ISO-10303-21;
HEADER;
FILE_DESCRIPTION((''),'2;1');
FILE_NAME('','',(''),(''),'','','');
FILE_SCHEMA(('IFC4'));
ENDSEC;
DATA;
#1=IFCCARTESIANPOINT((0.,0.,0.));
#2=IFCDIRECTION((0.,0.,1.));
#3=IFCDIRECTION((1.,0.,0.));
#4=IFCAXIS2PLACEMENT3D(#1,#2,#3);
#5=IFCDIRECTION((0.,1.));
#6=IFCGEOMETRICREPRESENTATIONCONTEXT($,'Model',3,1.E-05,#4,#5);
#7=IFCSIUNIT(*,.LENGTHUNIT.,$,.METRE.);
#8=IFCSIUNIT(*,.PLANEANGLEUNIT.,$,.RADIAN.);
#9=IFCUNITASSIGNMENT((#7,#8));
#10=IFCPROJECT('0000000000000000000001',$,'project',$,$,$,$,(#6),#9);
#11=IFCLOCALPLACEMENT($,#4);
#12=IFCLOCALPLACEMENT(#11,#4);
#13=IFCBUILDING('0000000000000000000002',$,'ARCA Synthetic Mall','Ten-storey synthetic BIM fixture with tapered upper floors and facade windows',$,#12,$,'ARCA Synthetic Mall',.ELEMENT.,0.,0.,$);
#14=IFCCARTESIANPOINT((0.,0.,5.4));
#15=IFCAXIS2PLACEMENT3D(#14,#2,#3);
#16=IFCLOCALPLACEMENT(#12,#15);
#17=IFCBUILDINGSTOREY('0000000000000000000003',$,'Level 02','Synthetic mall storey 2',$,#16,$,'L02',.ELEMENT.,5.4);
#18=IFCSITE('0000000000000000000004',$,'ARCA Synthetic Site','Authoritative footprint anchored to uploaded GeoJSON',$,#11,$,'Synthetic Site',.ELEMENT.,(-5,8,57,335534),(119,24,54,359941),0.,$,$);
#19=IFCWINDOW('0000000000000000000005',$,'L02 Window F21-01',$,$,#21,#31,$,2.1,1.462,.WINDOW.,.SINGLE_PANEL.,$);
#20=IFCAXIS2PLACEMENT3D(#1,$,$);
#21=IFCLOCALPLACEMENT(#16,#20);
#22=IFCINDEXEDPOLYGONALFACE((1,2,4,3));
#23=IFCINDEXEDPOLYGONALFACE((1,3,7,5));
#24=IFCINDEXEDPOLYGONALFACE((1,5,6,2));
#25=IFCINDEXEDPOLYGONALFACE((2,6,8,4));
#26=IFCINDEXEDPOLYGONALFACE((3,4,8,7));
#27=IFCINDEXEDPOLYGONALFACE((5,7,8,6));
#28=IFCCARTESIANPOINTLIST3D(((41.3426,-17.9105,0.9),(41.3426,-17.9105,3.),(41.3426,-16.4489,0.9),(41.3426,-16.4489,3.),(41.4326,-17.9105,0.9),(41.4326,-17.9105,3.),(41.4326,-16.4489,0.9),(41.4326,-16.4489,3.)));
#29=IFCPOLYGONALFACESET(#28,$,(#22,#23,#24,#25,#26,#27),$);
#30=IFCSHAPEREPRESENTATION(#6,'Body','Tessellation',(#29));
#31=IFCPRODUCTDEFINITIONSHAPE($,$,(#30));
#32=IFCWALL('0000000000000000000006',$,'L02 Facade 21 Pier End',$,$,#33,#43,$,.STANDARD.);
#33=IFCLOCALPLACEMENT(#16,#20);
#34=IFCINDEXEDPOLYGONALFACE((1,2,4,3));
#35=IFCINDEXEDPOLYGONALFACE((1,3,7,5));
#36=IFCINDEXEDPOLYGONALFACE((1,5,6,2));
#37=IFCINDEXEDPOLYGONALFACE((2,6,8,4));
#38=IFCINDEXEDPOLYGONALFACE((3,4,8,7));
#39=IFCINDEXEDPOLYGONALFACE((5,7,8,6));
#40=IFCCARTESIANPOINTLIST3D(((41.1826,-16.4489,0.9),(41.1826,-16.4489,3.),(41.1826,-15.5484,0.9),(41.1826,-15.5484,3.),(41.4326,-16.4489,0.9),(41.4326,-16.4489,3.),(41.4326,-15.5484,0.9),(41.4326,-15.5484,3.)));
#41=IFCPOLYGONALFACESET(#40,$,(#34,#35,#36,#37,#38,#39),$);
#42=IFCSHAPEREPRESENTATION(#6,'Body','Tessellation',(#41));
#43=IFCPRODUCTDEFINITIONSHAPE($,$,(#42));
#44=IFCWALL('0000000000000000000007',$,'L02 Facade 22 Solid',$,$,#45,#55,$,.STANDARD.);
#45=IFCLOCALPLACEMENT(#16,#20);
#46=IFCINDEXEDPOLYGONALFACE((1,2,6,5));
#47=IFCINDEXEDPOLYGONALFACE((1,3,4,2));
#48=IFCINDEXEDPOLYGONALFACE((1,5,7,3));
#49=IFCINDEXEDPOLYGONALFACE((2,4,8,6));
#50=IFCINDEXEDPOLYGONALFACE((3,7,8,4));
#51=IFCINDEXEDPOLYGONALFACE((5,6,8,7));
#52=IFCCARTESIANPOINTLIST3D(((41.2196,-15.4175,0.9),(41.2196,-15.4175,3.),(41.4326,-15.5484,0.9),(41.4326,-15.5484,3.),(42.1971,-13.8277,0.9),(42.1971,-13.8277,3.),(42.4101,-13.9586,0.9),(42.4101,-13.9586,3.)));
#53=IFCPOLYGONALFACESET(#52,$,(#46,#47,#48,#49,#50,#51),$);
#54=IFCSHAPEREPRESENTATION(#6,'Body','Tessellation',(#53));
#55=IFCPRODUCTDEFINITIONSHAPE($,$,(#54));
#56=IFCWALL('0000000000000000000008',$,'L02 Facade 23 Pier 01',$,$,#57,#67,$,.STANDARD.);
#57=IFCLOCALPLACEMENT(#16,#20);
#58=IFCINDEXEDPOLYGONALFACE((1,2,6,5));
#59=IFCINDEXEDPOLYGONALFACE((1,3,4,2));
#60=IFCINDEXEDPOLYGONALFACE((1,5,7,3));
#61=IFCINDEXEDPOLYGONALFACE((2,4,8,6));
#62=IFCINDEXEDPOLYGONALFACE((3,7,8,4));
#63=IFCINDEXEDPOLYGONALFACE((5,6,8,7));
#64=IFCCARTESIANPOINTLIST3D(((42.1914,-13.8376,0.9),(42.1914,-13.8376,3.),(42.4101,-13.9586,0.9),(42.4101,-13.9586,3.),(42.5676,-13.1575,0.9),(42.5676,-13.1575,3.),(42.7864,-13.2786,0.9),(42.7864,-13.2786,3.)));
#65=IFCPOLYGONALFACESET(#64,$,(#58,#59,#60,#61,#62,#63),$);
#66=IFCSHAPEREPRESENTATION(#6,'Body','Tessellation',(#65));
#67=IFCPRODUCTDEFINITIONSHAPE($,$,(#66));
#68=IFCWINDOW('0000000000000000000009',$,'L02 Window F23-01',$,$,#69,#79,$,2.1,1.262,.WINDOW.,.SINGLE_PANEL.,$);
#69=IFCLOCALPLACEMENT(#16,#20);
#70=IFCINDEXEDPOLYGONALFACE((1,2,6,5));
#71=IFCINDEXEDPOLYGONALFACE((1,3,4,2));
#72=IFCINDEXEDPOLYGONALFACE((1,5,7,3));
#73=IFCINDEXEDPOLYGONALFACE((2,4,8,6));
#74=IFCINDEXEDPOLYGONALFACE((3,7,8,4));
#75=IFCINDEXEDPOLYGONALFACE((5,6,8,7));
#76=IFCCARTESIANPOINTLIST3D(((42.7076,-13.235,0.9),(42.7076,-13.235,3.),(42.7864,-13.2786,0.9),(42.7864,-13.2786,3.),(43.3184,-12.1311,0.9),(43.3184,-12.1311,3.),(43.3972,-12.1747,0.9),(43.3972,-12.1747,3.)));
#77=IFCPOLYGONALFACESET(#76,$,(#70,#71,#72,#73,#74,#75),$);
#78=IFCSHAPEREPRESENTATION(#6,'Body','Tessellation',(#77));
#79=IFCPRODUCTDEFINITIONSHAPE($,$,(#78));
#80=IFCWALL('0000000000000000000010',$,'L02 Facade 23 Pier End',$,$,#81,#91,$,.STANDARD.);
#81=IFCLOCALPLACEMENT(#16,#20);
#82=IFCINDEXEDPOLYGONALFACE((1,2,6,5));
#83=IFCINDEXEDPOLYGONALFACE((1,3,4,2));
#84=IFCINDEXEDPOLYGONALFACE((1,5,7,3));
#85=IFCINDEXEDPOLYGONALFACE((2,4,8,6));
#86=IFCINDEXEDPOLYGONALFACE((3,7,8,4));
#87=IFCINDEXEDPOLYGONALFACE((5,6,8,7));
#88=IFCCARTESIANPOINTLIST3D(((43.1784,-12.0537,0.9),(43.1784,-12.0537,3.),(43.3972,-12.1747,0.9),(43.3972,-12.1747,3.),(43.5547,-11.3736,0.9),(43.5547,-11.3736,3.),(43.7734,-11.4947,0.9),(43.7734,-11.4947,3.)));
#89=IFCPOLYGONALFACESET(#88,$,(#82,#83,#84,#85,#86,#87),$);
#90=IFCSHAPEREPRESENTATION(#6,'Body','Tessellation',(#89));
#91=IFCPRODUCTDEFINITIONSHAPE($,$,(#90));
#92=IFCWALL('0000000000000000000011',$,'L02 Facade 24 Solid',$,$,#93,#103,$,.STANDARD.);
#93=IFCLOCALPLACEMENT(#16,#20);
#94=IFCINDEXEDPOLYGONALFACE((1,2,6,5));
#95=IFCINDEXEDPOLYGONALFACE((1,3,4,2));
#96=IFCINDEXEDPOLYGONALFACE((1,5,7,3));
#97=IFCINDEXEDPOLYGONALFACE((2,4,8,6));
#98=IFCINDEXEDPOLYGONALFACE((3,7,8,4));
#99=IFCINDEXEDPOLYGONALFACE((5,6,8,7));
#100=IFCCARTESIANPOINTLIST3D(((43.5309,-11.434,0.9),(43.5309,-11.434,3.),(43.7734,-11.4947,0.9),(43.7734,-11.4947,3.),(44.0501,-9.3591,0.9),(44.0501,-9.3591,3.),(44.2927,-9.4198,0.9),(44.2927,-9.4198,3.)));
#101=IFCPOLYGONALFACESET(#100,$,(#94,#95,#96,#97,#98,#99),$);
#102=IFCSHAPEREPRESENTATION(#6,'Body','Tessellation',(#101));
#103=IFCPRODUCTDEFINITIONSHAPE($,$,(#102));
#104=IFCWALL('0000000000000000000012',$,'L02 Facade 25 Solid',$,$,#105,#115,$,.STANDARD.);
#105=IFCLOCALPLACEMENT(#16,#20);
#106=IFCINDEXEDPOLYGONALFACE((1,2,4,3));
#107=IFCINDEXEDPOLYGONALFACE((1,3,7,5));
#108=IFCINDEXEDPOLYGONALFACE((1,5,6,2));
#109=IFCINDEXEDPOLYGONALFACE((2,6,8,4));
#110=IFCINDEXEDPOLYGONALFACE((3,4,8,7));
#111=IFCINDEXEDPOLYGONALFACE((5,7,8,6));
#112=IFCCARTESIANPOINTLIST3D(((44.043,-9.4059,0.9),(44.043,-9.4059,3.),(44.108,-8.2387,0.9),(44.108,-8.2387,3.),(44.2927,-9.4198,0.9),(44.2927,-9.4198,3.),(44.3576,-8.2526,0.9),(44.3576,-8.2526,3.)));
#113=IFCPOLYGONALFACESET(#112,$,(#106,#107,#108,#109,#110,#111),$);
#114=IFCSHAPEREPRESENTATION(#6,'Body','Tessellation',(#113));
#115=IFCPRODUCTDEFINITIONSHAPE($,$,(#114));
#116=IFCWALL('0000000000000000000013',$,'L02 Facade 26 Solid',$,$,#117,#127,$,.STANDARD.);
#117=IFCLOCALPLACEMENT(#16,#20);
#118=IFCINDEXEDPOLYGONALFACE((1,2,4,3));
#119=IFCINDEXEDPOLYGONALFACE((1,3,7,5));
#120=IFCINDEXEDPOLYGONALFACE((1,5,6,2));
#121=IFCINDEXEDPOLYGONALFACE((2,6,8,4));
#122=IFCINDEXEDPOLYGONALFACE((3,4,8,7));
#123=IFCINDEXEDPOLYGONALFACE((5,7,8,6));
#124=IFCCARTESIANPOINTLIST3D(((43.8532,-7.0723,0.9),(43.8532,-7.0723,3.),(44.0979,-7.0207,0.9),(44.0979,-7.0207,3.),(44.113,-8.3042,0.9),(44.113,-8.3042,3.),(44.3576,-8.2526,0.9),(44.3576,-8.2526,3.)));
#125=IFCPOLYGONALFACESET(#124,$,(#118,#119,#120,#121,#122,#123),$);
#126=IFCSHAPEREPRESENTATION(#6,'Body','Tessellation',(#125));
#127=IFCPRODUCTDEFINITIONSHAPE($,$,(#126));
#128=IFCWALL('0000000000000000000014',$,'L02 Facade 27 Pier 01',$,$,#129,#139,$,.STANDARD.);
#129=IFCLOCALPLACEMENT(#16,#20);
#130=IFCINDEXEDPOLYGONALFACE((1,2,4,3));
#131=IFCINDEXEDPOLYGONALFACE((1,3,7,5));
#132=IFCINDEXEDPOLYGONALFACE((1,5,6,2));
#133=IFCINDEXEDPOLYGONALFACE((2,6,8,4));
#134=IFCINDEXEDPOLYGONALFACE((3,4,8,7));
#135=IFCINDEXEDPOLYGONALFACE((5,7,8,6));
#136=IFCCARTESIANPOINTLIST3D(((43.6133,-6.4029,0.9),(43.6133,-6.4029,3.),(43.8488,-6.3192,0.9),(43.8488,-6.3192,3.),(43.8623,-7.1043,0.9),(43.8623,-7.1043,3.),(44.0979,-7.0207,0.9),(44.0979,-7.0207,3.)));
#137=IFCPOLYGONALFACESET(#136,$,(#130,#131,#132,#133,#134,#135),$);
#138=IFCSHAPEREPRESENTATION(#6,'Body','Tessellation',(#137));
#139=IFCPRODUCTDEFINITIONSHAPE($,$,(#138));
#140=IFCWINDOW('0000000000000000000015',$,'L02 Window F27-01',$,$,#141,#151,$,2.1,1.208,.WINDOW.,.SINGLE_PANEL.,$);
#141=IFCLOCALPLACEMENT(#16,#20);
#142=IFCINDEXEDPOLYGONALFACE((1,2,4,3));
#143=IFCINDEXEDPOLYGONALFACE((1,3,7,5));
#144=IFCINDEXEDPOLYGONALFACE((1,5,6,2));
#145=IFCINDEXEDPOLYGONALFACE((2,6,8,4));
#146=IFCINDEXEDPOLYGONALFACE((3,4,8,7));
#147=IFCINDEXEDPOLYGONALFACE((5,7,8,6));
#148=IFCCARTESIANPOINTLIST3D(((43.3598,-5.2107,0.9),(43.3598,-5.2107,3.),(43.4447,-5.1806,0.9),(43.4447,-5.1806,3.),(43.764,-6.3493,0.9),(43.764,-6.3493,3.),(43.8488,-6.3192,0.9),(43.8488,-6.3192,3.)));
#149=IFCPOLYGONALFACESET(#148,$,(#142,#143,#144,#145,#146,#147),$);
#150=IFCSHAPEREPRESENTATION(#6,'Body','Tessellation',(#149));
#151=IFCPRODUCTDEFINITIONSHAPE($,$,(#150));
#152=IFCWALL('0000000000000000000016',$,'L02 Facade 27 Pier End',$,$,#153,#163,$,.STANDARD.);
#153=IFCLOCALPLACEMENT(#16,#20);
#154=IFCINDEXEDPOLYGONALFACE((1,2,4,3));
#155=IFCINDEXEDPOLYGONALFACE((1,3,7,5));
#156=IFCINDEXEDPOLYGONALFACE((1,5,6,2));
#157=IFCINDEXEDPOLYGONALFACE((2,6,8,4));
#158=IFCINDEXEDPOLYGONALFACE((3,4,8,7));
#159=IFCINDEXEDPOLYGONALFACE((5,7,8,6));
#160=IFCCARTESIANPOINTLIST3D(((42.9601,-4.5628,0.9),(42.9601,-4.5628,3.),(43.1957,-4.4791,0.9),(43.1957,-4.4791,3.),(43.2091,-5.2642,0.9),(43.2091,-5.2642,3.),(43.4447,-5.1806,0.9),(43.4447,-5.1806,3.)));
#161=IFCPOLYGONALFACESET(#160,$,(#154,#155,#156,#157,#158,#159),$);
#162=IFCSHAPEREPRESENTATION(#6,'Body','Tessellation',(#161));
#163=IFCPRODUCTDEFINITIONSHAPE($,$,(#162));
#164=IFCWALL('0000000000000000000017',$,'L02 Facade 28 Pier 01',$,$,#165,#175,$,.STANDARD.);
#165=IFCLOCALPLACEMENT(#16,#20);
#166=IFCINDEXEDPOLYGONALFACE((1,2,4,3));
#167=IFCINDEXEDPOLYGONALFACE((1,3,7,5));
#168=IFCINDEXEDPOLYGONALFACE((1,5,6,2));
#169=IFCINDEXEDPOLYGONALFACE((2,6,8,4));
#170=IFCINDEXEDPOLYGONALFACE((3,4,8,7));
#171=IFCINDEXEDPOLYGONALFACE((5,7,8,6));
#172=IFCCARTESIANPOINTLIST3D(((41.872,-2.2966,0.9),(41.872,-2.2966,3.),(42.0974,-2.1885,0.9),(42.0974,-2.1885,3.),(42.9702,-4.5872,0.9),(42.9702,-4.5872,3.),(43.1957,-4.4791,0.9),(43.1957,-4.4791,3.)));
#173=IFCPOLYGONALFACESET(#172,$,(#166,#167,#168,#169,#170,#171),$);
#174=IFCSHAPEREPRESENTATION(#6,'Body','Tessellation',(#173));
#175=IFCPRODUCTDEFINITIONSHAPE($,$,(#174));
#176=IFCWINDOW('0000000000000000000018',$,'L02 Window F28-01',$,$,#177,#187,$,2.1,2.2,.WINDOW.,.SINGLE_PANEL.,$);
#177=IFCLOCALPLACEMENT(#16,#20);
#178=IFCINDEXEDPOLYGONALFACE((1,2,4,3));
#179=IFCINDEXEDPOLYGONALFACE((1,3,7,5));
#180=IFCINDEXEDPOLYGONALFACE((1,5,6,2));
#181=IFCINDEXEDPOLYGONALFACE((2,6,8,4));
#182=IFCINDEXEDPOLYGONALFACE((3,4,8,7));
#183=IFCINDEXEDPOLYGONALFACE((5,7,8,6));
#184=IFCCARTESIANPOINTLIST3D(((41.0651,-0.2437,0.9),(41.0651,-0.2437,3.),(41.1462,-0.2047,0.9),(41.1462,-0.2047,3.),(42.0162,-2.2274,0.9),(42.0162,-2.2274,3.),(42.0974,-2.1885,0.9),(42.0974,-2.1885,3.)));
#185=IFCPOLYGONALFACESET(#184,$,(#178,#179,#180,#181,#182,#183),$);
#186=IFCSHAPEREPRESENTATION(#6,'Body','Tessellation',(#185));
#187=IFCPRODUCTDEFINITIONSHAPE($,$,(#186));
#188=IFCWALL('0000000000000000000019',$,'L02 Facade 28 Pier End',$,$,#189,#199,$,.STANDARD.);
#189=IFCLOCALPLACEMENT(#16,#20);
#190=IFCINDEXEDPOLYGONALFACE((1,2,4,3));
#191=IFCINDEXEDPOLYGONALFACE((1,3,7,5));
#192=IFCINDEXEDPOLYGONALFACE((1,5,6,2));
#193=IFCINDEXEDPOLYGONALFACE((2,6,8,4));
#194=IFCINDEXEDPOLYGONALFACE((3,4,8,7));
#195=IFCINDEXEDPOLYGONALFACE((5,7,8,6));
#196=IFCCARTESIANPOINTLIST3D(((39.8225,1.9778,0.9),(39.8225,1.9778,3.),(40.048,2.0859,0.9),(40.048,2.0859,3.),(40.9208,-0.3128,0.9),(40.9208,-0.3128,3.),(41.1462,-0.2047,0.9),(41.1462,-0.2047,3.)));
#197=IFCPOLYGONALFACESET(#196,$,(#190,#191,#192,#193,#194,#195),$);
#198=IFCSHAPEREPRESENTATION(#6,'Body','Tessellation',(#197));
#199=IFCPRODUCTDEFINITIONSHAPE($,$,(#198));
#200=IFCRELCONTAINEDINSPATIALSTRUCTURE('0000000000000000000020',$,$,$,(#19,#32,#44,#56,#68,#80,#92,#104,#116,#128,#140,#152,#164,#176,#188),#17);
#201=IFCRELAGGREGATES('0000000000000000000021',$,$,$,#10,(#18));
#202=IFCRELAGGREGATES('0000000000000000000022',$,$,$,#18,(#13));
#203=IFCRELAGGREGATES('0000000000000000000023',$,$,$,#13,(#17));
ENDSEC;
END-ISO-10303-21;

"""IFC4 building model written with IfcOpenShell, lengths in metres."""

from ifc_helpers import new_model, si_unit, direction, frame, origin_with_axes, place, context, project, spatial, polyline, outline, extrude, element, save


model = new_model("IFC4")

# Units and contexts
model_context = context("Model", 3, precision=1e-05, world=origin_with_axes(), true_north=direction((0.0, 1.0)))
ifc_project = project(units=[si_unit("LENGTHUNIT", "METRE"), si_unit("PLANEANGLEUNIT", "RADIAN")], contexts=[model_context])

# Site, building, storey
site_placement = place(None, origin_with_axes())
site = spatial("IfcSite", under=ifc_project, at=site_placement, Name="ARCA Synthetic Site", Description="Authoritative footprint anchored to uploaded GeoJSON", LongName="Synthetic Site", CompositionType="ELEMENT", RefLatitude=(-5, 8, 57, 335534), RefLongitude=(119, 24, 54, 359941), RefElevation=0.0)
building_placement = place(site_placement, origin_with_axes())
building = spatial("IfcBuilding", under=site, at=building_placement, Name="ARCA Synthetic Mall", Description="Ten-storey synthetic BIM fixture with tapered upper floors and facade windows", LongName="ARCA Synthetic Mall", CompositionType="ELEMENT", ElevationOfRefHeight=0.0, ElevationOfTerrain=0.0)
storey_placement = place(building_placement, frame((0.0, 0.0, 5.4), z_axis=(0.0, 0.0, 1.0), x_axis=(1.0, 0.0, 0.0)))
storey = spatial("IfcBuildingStorey", under=building, at=storey_placement, Name="Level 02", Description="Synthetic mall storey 2", LongName="L02", CompositionType="ELEMENT", Elevation=5.4)

# Window
window_1_placement = place(storey_placement, frame((0.0, 0.0, 0.9), z_axis=(0.0, 0.0, 1.0), x_axis=(1.0, 0.0, 0.0)))
element("IfcWindow", 1, at=window_1_placement, inside=storey, Name="L02 Window F21-01", OverallHeight=2.1, OverallWidth=1.462, PartitioningType="SINGLE_PANEL", PredefinedType="WINDOW", context=model_context, shape_type="SweptSolid", body=[
    extrude(outline(polyline([(41.4326, -17.9105), (41.4326, -16.4489), (41.3426, -16.4489), (41.3426, -17.9105), (41.4326, -17.9105)])), origin_with_axes(), (0.0, 0.0, 1.0), 2.1),
])

# Walls
wall_1_placement = place(storey_placement, frame((0.0, 0.0, 0.9), z_axis=(0.0, 0.0, 1.0), x_axis=(1.0, 0.0, 0.0)))
element("IfcWall", 2, at=wall_1_placement, inside=storey, Name="L02 Facade 21 Pier End", PredefinedType="STANDARD", context=model_context, shape_type="SweptSolid", body=[
    extrude(outline(polyline([(41.4326, -16.4489), (41.4326, -15.5484), (41.1826, -15.5484), (41.1826, -16.4489), (41.4326, -16.4489)])), origin_with_axes(), (0.0, 0.0, 1.0), 2.1),
])
wall_2_placement = place(storey_placement, frame((0.0, 0.0, 0.9), z_axis=(0.0, 0.0, 1.0), x_axis=(1.0, 0.0, 0.0)))
element("IfcWall", 3, at=wall_2_placement, inside=storey, Name="L02 Facade 22 Solid", PredefinedType="STANDARD", context=model_context, shape_type="SweptSolid", body=[
    extrude(outline(polyline([(41.4326, -15.5484), (42.4101, -13.9586), (42.1971, -13.8277), (41.2196, -15.4175), (41.4326, -15.5484)])), origin_with_axes(), (0.0, 0.0, 1.0), 2.1),
])
wall_3_placement = place(storey_placement, frame((0.0, 0.0, 0.9), z_axis=(0.0, 0.0, 1.0), x_axis=(1.0, 0.0, 0.0)))
element("IfcWall", 4, at=wall_3_placement, inside=storey, Name="L02 Facade 23 Pier 01", PredefinedType="STANDARD", context=model_context, shape_type="SweptSolid", body=[
    extrude(outline(polyline([(42.4101, -13.9586), (42.7864, -13.2786), (42.5676, -13.1575), (42.1914, -13.8376), (42.4101, -13.9586)])), origin_with_axes(), (0.0, 0.0, 1.0), 2.1),
])

# Window
window_2_placement = place(storey_placement, frame((0.0, 0.0, 0.9), z_axis=(0.0, 0.0, 1.0), x_axis=(1.0, 0.0, 0.0)))
element("IfcWindow", 5, at=window_2_placement, inside=storey, Name="L02 Window F23-01", OverallHeight=2.1, OverallWidth=1.262, PartitioningType="SINGLE_PANEL", PredefinedType="WINDOW", context=model_context, shape_type="SweptSolid", body=[
    extrude(outline(polyline([(42.7864, -13.2786), (43.3972, -12.1747), (43.3184, -12.1311), (42.7076, -13.235), (42.7864, -13.2786)])), origin_with_axes(), (0.0, 0.0, 1.0), 2.1),
])

# Walls
wall_4_placement = place(storey_placement, frame((0.0, 0.0, 0.9), z_axis=(0.0, 0.0, 1.0), x_axis=(1.0, 0.0, 0.0)))
element("IfcWall", 6, at=wall_4_placement, inside=storey, Name="L02 Facade 23 Pier End", PredefinedType="STANDARD", context=model_context, shape_type="SweptSolid", body=[
    extrude(outline(polyline([(43.3972, -12.1747), (43.7734, -11.4947), (43.5547, -11.3736), (43.1784, -12.0537), (43.3972, -12.1747)])), origin_with_axes(), (0.0, 0.0, 1.0), 2.1),
])
wall_5_placement = place(storey_placement, frame((0.0, 0.0, 0.9), z_axis=(0.0, 0.0, 1.0), x_axis=(1.0, 0.0, 0.0)))
element("IfcWall", 7, at=wall_5_placement, inside=storey, Name="L02 Facade 24 Solid", PredefinedType="STANDARD", context=model_context, shape_type="SweptSolid", body=[
    extrude(outline(polyline([(43.7734, -11.4947), (44.2927, -9.4198), (44.0501, -9.3591), (43.5309, -11.434), (43.7734, -11.4947)])), origin_with_axes(), (0.0, 0.0, 1.0), 2.1),
])
wall_6_placement = place(storey_placement, frame((0.0, 0.0, 0.9), z_axis=(0.0, 0.0, 1.0), x_axis=(1.0, 0.0, 0.0)))
element("IfcWall", 8, at=wall_6_placement, inside=storey, Name="L02 Facade 25 Solid", PredefinedType="STANDARD", context=model_context, shape_type="SweptSolid", body=[
    extrude(outline(polyline([(44.2927, -9.4198), (44.3576, -8.2526), (44.108, -8.2387), (44.043, -9.4059), (44.2927, -9.4198)])), origin_with_axes(), (0.0, 0.0, 1.0), 2.1),
])
wall_7_placement = place(storey_placement, frame((0.0, 0.0, 0.9), z_axis=(0.0, 0.0, 1.0), x_axis=(1.0, 0.0, 0.0)))
element("IfcWall", 9, at=wall_7_placement, inside=storey, Name="L02 Facade 26 Solid", PredefinedType="STANDARD", context=model_context, shape_type="SweptSolid", body=[
    extrude(outline(polyline([(44.3576, -8.2526), (44.0979, -7.0207), (43.8532, -7.0723), (44.113, -8.3042), (44.3576, -8.2526)])), origin_with_axes(), (0.0, 0.0, 1.0), 2.1),
])
wall_8_placement = place(storey_placement, frame((0.0, 0.0, 0.9), z_axis=(0.0, 0.0, 1.0), x_axis=(1.0, 0.0, 0.0)))
element("IfcWall", 10, at=wall_8_placement, inside=storey, Name="L02 Facade 27 Pier 01", PredefinedType="STANDARD", context=model_context, shape_type="SweptSolid", body=[
    extrude(outline(polyline([(44.0979, -7.0207), (43.8488, -6.3192), (43.6133, -6.4029), (43.8623, -7.1043), (44.0979, -7.0207)])), origin_with_axes(), (0.0, 0.0, 1.0), 2.1),
])

# Window
window_3_placement = place(storey_placement, frame((0.0, 0.0, 0.9), z_axis=(0.0, 0.0, 1.0), x_axis=(1.0, 0.0, 0.0)))
element("IfcWindow", 11, at=window_3_placement, inside=storey, Name="L02 Window F27-01", OverallHeight=2.1, OverallWidth=1.208, PartitioningType="SINGLE_PANEL", PredefinedType="WINDOW", context=model_context, shape_type="SweptSolid", body=[
    extrude(outline(polyline([(43.8488, -6.3192), (43.4447, -5.1806), (43.3598, -5.2107), (43.764, -6.3493), (43.8488, -6.3192)])), origin_with_axes(), (0.0, 0.0, 1.0), 2.1),
])

# Walls
wall_9_placement = place(storey_placement, frame((0.0, 0.0, 0.9), z_axis=(0.0, 0.0, 1.0), x_axis=(1.0, 0.0, 0.0)))
element("IfcWall", 12, at=wall_9_placement, inside=storey, Name="L02 Facade 27 Pier End", PredefinedType="STANDARD", context=model_context, shape_type="SweptSolid", body=[
    extrude(outline(polyline([(43.4447, -5.1806), (43.1957, -4.4791), (42.9601, -4.5628), (43.2091, -5.2642), (43.4447, -5.1806)])), origin_with_axes(), (0.0, 0.0, 1.0), 2.1),
])
wall_10_placement = place(storey_placement, frame((0.0, 0.0, 0.9), z_axis=(0.0, 0.0, 1.0), x_axis=(1.0, 0.0, 0.0)))
element("IfcWall", 13, at=wall_10_placement, inside=storey, Name="L02 Facade 28 Pier 01", PredefinedType="STANDARD", context=model_context, shape_type="SweptSolid", body=[
    extrude(outline(polyline([(43.1957, -4.4791), (42.0974, -2.1885), (41.872, -2.2966), (42.9702, -4.5872), (43.1957, -4.4791)])), origin_with_axes(), (0.0, 0.0, 1.0), 2.1),
])

# Window
window_4_placement = place(storey_placement, frame((0.0, 0.0, 0.9), z_axis=(0.0, 0.0, 1.0), x_axis=(1.0, 0.0, 0.0)))
element("IfcWindow", 14, at=window_4_placement, inside=storey, Name="L02 Window F28-01", OverallHeight=2.1, OverallWidth=2.2, PartitioningType="SINGLE_PANEL", PredefinedType="WINDOW", context=model_context, shape_type="SweptSolid", body=[
    extrude(outline(polyline([(42.0974, -2.1885), (41.1462, -0.2047), (41.0651, -0.2437), (42.0162, -2.2274), (42.0974, -2.1885)])), origin_with_axes(), (0.0, 0.0, 1.0), 2.1),
])

# Wall
wall_11_placement = place(storey_placement, frame((0.0, 0.0, 0.9), z_axis=(0.0, 0.0, 1.0), x_axis=(1.0, 0.0, 0.0)))
element("IfcWall", 15, at=wall_11_placement, inside=storey, Name="L02 Facade 28 Pier End", PredefinedType="STANDARD", context=model_context, shape_type="SweptSolid", body=[
    extrude(outline(polyline([(41.1462, -0.2047), (40.048, 2.0859), (39.8225, 1.9778), (40.9208, -0.3128), (41.1462, -0.2047)])), origin_with_axes(), (0.0, 0.0, 1.0), 2.1),
])

save(model, "model.ifc")
